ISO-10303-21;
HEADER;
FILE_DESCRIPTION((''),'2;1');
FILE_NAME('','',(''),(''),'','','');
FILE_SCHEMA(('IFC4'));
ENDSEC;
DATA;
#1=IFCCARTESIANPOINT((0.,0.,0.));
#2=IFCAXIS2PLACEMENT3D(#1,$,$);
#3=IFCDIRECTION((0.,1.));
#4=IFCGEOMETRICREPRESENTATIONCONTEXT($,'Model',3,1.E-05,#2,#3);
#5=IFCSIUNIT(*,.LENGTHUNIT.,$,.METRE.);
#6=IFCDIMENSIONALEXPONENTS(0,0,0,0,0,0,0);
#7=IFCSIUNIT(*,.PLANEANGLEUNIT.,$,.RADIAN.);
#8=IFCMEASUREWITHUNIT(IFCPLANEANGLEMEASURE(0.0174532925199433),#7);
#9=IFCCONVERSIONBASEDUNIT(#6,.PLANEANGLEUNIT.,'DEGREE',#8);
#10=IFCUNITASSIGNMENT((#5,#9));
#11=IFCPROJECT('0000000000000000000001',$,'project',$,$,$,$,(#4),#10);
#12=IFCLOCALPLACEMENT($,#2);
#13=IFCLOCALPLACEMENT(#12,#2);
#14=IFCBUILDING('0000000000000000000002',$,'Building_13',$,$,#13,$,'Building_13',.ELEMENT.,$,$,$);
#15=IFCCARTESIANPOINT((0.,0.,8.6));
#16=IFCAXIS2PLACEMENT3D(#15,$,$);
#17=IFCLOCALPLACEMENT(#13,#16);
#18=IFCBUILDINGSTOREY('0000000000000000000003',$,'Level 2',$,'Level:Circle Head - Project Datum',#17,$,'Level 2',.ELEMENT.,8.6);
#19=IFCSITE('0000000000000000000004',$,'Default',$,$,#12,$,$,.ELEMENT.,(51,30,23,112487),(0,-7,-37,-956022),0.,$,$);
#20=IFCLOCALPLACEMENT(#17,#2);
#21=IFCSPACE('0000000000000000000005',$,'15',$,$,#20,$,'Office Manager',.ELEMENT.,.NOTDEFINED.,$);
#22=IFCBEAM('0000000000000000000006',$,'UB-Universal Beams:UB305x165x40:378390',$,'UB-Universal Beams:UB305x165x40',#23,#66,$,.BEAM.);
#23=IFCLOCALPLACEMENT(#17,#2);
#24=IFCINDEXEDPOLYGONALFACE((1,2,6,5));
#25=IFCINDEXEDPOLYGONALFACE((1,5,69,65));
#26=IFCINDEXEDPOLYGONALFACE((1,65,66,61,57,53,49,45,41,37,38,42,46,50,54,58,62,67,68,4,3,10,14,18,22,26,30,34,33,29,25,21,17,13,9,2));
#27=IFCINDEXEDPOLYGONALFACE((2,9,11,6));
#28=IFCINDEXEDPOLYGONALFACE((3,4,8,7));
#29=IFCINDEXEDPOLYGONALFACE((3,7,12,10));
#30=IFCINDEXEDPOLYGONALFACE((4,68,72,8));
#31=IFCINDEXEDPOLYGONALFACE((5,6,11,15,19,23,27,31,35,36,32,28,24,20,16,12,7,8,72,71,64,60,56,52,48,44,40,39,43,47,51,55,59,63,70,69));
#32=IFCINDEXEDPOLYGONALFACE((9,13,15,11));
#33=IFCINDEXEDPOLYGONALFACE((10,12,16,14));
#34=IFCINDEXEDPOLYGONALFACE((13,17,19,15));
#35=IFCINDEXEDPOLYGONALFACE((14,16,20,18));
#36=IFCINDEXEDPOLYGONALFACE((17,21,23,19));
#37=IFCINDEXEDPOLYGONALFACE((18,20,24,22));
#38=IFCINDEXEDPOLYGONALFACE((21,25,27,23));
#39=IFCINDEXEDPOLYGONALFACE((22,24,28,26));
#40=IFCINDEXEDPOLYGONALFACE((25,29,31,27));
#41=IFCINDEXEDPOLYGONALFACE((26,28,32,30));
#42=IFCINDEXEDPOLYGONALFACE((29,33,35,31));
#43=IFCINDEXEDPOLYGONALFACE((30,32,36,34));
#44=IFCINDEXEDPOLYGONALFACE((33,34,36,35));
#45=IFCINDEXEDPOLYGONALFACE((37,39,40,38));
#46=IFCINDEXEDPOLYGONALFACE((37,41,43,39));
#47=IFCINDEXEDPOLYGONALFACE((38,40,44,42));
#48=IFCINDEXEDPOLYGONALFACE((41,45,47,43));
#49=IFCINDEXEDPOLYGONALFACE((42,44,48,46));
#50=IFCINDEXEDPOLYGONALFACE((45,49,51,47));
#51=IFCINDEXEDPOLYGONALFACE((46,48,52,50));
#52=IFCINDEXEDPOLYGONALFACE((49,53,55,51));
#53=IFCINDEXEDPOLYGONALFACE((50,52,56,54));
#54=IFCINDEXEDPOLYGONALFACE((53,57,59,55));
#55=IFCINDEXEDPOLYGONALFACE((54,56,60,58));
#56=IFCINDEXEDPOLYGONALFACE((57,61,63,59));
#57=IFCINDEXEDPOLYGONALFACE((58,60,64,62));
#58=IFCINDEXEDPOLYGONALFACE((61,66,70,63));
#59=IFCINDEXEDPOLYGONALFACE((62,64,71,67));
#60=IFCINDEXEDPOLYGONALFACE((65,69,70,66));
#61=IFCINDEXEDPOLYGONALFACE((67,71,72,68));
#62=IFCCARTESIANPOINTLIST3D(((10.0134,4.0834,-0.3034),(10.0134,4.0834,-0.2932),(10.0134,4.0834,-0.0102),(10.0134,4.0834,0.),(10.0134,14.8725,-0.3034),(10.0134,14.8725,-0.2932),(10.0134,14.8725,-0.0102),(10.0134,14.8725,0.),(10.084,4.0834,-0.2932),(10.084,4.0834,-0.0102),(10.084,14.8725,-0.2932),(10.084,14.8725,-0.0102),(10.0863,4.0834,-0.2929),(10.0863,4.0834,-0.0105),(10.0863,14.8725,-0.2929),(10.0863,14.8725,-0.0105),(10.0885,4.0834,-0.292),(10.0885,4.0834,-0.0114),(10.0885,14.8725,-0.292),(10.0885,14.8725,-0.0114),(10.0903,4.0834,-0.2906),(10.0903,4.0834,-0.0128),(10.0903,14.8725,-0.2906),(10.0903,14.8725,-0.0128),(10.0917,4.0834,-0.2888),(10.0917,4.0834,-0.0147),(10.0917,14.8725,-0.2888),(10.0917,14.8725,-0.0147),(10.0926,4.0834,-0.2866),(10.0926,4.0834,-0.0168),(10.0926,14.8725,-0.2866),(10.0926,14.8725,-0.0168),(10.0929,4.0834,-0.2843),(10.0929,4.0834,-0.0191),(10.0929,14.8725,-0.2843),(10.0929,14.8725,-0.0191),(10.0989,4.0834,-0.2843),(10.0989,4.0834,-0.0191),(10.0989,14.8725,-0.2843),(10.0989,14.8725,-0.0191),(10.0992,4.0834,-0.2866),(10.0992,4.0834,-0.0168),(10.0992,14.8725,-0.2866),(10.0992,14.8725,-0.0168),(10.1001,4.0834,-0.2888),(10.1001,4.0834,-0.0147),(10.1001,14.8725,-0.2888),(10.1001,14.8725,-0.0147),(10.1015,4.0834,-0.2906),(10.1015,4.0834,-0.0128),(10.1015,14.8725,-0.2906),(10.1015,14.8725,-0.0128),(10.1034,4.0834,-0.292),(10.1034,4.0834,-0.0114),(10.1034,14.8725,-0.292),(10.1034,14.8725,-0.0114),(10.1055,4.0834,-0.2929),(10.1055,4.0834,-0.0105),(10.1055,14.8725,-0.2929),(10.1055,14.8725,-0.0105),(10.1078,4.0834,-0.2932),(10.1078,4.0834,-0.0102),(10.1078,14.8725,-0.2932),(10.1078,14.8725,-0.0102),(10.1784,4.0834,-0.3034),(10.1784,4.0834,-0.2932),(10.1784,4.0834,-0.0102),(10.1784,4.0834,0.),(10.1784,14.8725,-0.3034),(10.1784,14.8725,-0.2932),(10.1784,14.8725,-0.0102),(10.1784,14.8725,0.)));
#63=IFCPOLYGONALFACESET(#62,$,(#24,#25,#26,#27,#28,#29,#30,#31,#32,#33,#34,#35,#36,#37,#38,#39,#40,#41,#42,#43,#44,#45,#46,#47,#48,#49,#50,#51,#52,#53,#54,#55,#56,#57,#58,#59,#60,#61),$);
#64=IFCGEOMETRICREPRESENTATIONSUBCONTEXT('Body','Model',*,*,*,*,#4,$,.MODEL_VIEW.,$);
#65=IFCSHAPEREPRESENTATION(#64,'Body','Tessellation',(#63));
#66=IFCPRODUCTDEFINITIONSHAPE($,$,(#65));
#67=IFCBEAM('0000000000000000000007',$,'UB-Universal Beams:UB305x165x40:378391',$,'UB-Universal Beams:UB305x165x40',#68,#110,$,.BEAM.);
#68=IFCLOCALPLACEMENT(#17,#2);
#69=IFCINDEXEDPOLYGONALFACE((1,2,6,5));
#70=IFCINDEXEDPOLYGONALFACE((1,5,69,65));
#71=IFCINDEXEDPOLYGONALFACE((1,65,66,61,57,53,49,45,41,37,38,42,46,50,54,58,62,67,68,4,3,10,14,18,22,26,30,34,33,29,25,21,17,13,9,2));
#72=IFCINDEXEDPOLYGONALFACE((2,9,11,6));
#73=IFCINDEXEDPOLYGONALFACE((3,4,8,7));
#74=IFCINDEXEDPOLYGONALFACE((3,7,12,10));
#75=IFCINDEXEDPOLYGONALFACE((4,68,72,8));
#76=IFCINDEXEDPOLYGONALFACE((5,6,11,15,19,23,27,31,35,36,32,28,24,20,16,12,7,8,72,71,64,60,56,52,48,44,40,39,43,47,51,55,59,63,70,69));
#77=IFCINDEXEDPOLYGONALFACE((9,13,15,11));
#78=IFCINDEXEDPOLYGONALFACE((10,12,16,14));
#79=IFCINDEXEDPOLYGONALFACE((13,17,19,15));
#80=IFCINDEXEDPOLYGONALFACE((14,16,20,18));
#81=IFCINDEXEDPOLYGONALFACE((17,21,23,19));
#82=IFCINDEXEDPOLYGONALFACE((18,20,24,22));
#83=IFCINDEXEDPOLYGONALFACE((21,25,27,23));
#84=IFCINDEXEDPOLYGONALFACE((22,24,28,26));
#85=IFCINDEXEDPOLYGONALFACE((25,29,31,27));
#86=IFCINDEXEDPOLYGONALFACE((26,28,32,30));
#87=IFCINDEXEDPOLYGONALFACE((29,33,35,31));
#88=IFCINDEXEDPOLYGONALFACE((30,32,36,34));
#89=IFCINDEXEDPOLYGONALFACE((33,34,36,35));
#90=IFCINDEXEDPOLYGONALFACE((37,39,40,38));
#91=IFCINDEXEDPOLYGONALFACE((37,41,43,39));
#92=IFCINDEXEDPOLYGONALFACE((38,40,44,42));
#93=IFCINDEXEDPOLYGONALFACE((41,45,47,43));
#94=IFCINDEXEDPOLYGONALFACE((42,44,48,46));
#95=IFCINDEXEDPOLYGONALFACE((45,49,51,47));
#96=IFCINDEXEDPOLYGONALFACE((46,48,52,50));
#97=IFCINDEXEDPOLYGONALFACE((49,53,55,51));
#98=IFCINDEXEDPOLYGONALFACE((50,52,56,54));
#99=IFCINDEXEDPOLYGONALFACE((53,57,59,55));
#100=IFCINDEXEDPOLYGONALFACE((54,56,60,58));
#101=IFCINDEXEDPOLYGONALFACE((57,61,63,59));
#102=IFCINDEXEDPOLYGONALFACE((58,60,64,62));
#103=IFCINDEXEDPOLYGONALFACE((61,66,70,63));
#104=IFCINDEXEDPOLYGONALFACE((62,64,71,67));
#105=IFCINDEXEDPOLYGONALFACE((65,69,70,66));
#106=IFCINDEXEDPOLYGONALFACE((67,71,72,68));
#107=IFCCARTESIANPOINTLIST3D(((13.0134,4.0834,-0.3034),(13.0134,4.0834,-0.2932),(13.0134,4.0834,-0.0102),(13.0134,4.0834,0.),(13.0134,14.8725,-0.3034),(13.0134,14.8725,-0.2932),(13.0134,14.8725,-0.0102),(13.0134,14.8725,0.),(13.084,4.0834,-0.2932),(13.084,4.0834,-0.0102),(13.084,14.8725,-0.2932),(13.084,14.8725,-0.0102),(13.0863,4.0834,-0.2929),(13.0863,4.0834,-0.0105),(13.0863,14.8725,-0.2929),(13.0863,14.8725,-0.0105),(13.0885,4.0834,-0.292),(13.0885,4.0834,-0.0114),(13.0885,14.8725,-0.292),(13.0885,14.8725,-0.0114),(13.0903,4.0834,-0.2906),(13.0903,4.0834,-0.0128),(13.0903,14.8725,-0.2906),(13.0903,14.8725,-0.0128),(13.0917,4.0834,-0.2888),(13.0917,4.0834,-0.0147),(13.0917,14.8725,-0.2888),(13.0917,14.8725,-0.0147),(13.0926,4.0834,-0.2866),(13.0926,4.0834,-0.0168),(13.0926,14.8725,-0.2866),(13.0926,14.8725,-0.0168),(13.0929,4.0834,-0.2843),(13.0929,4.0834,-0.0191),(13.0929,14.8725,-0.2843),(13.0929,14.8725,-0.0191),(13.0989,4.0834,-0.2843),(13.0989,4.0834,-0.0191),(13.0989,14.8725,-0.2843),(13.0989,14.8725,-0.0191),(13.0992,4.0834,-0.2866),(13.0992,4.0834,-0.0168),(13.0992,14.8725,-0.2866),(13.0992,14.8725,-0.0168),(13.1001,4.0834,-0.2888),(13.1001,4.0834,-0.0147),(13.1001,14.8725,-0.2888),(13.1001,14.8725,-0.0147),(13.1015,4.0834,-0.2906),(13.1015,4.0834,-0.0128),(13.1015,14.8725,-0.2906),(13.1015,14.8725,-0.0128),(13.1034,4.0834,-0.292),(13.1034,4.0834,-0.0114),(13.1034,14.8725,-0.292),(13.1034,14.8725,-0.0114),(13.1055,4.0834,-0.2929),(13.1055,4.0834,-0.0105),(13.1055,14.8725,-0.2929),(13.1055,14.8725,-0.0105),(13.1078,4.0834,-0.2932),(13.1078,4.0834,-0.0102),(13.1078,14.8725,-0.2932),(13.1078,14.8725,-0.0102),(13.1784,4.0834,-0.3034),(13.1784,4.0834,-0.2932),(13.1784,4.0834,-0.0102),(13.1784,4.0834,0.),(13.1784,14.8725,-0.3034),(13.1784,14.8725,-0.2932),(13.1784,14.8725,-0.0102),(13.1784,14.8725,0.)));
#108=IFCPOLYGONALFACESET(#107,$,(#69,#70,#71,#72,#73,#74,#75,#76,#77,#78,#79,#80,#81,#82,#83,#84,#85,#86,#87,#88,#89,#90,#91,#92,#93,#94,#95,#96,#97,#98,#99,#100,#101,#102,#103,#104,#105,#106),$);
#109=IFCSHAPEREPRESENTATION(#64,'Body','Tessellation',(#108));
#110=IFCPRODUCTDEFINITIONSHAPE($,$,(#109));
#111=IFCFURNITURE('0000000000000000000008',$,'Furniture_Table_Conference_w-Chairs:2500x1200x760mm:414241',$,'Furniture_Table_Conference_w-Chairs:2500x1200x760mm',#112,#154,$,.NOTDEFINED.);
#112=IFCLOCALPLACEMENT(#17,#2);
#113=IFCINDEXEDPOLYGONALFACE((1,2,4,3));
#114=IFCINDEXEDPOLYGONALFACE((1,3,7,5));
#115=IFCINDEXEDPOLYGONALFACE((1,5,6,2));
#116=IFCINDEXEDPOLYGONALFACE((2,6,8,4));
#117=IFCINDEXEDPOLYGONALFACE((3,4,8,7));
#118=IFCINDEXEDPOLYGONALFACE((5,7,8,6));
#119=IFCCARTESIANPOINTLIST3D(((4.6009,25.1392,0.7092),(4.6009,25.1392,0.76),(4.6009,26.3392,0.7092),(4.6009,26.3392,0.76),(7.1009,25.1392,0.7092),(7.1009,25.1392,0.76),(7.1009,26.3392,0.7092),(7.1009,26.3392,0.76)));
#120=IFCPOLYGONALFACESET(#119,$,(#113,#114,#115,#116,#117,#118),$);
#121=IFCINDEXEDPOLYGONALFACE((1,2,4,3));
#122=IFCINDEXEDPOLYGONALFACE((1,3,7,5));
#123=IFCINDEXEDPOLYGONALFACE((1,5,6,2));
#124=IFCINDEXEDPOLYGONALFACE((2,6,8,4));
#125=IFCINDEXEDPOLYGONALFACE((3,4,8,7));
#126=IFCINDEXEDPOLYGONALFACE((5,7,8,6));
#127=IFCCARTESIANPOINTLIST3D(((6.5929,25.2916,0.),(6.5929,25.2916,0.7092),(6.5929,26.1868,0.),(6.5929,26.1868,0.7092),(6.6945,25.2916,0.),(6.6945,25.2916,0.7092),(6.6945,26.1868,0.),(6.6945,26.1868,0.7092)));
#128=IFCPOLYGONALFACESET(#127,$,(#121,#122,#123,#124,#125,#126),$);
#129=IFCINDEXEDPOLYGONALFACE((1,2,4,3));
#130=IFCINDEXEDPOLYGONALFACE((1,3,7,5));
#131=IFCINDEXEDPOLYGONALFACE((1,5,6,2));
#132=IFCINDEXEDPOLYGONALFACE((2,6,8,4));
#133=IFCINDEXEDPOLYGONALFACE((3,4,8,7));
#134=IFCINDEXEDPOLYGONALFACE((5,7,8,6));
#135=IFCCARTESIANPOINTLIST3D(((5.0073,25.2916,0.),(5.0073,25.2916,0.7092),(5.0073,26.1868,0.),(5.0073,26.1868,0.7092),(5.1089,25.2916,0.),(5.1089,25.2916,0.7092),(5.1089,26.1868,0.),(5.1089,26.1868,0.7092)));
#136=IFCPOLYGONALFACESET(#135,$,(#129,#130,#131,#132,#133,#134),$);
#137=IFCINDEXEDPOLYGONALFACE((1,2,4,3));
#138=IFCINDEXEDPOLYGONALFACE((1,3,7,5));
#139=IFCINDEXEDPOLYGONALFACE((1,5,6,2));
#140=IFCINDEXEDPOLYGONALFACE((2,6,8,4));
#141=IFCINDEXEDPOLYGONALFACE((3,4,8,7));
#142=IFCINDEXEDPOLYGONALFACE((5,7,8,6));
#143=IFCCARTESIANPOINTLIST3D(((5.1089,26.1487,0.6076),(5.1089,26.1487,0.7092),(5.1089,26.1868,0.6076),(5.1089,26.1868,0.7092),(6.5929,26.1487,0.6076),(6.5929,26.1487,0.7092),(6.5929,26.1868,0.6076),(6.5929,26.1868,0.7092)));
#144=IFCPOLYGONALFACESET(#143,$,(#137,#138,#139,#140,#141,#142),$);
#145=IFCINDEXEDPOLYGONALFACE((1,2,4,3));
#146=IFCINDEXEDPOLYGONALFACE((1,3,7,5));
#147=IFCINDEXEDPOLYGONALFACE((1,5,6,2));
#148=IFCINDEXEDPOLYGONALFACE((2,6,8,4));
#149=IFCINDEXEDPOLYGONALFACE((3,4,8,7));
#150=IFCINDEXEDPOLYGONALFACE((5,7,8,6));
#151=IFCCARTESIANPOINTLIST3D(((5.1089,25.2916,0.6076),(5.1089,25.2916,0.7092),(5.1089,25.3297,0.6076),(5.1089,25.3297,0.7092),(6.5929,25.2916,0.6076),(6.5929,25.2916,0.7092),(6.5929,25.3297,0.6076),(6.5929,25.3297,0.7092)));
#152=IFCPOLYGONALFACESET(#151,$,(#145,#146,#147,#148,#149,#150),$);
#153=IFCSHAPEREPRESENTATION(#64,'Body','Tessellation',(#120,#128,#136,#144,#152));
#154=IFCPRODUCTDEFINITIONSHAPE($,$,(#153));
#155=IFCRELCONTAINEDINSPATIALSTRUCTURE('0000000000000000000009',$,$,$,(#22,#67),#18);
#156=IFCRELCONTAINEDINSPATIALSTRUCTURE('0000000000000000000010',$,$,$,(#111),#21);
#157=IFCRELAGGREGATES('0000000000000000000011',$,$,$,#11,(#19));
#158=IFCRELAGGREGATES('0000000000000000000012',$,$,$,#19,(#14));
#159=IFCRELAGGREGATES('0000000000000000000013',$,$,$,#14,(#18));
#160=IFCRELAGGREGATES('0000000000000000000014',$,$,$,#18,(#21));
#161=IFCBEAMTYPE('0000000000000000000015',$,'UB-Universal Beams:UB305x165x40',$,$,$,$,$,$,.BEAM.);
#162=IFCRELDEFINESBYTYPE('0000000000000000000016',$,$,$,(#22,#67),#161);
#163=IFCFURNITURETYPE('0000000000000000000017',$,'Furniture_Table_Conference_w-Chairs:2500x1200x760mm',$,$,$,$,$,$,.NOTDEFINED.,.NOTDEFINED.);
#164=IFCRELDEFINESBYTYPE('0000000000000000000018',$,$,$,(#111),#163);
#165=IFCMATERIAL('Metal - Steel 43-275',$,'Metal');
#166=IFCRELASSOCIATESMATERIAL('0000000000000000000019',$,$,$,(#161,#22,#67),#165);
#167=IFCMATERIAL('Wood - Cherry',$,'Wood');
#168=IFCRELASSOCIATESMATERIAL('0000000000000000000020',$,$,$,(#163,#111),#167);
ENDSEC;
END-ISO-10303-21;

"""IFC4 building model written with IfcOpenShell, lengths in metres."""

from ifc_helpers import new_model, entity, si_unit, converted_unit, direction, frame, origin, place, context, subcontext, project, spatial, line, arc, indexed_curve, outline, extrude, source, transform, mapped, material, type_object, type_shapes, element, save


model = new_model("IFC4")

# Units and contexts
model_context = context("Model", 3, precision=1e-05, world=origin(), true_north=direction((0.0, 1.0)))
body_context = subcontext(model_context, "Body", "Model", "MODEL_VIEW")
ifc_project = project(units=[si_unit("LENGTHUNIT", "METRE"), converted_unit("PLANEANGLEUNIT", "DEGREE", entity("IfcPlaneAngleMeasure", 0.0174532925199433), si_unit("PLANEANGLEUNIT", "RADIAN"), dimensions=[0, 0, 0, 0, 0, 0, 0])], contexts=[model_context])

# Site, building, storey
site_placement = place(None, origin())
site = spatial("IfcSite", under=ifc_project, at=site_placement, Name="Default", CompositionType="ELEMENT", RefLatitude=(51, 30, 23, 112487), RefLongitude=(0, -7, -37, -956022), RefElevation=0.0)
building_placement = place(site_placement, origin())
building = spatial("IfcBuilding", under=site, at=building_placement, Name="Building_13", LongName="Building_13", CompositionType="ELEMENT")
storey_placement = place(building_placement, frame((0.0, 0.0, 8.6)))
storey = spatial("IfcBuildingStorey", under=building, at=storey_placement, Name="Level 2", ObjectType="Level:Circle Head - Project Datum", LongName="Level 2", CompositionType="ELEMENT", Elevation=8.6)

# Beams
ifc_material_1 = material(Name="Metal - Steel 43-275", Category="Metal")
beam_type_1 = type_object("IfcBeamType", Name="UB-Universal Beams:UB305x165x40", PredefinedType="BEAM", material=ifc_material_1)
shared_shape_1 = source(origin(), body_context, "Body", "SweptSolid", [
    extrude(outline(indexed_curve([(-0.0825, -0.1415), (-0.0825, -0.1517), (0.0825, -0.1517), (0.0825, -0.1415), (0.0119, -0.1415), (0.0056, -0.1389), (0.003, -0.1326), (0.003, 0.1326), (0.0056, 0.1389), (0.0119, 0.1415), (0.0825, 0.1415), (0.0825, 0.1517), (-0.0825, 0.1517), (-0.0825, 0.1415), (-0.0119, 0.1415), (-0.0056, 0.1389), (-0.003, 0.1326), (-0.003, -0.1326), (-0.0056, -0.1389), (-0.0119, -0.1415)], segments=[line(1, 2, 3, 4, 5), arc(5, 6, 7), line(7, 8), arc(8, 9, 10), line(10, 11, 12, 13, 14, 15), arc(15, 16, 17), line(17, 18), arc(18, 19, 20), line(20, 1)], self_intersect=False)), frame((-5.3945, 0.0, 0.0), z_axis=(-1.0, 0.0, 0.0), x_axis=(0.0, -1.0, 0.0)), (0.0, 0.0, -1.0), 10.7891),
])
type_shapes(beam_type_1, [shared_shape_1])
for number, where, z_axis, x_axis, name in (
    (1, (10.0959, 9.4779, -0.1517), (0.0, 0.0, 1.0), (0.0, 1.0, 0.0), "UB-Universal Beams:UB305x165x40:378390"),
    (2, (13.0959, 9.4779, -0.1517), (0.0, 0.0, 1.0), (0.0, -1.0, 0.0), "UB-Universal Beams:UB305x165x40:378391"),
):
    element("IfcBeam", number, at=place(storey_placement, frame(where, z_axis=z_axis, x_axis=x_axis)), inside=storey, type_object=beam_type_1, material=ifc_material_1, Name=name, ObjectType="UB-Universal Beams:UB305x165x40", PredefinedType="BEAM", context=body_context, shape_type="MappedRepresentation", body=[
        mapped(shared_shape_1, transform((0.0, 0.0, 0.0), scale=1.0)),
    ])

# Shared definitions
space_placement = place(storey_placement, origin())
space = spatial("IfcSpace", under=storey, at=space_placement, Name="15", LongName="Office Manager", CompositionType="ELEMENT", PredefinedType="NOTDEFINED")

# Furniture
ifc_material_2 = material(Name="Wood - Cherry", Category="Wood")
furniture_type_1 = type_object("IfcFurnitureType", Name="Furniture_Table_Conference_w-Chairs:2500x1200x760mm", AssemblyPlace="NOTDEFINED", PredefinedType="NOTDEFINED", material=ifc_material_2)
shared_shape_2 = source(origin(), body_context, "Body", "SweptSolid", [
    extrude(outline(indexed_curve([(-0.6, -1.25), (0.6, -1.25), (0.6, 1.25), (-0.6, 1.25), (-0.6, -1.25)], self_intersect=False)), frame((0.0, 0.0, 0.7092), z_axis=(0.0, 0.0, 1.0), x_axis=(0.0, 1.0, 0.0)), (0.0, 0.0, 1.0), 0.0508),
    extrude(outline(indexed_curve([(-0.4476, -0.0508), (0.4476, -0.0508), (0.4476, 0.0508), (-0.4476, 0.0508), (-0.4476, -0.0508)], self_intersect=False)), frame((0.7928, 0.0, 0.0), z_axis=(0.0, 0.0, 1.0), x_axis=(0.0, 1.0, 0.0)), (0.0, 0.0, 1.0), 0.7092),
    extrude(outline(indexed_curve([(-0.4476, -0.0508), (0.4476, -0.0508), (0.4476, 0.0508), (-0.4476, 0.0508), (-0.4476, -0.0508)], self_intersect=False)), frame((-0.7928, 0.0, 0.0), z_axis=(0.0, 0.0, 1.0), x_axis=(0.0, 1.0, 0.0)), (0.0, 0.0, 1.0), 0.7092),
    extrude(outline(indexed_curve([(-0.742, -0.0191), (0.742, -0.0191), (0.742, 0.0191), (-0.742, 0.0191), (-0.742, -0.0191)], self_intersect=False)), frame((0.0, 0.4286, 0.6076), z_axis=(0.0, 0.0, 1.0), x_axis=(-1.0, 0.0, 0.0)), (0.0, 0.0, 1.0), 0.1016),
    extrude(outline(indexed_curve([(-0.019, -0.742), (0.019, -0.742), (0.019, 0.742), (-0.019, 0.742), (-0.019, -0.742)], self_intersect=False)), frame((0.0, -0.4286, 0.6076), z_axis=(0.0, 0.0, 1.0), x_axis=(0.0, 1.0, 0.0)), (0.0, 0.0, 1.0), 0.1016),
])
type_shapes(furniture_type_1, [shared_shape_2])
furniture_1_placement = place(space_placement, frame((5.8509, 25.7392, 0.0)))
element("IfcFurniture", 3, at=furniture_1_placement, inside=space, type_object=furniture_type_1, material=ifc_material_2, Name="Furniture_Table_Conference_w-Chairs:2500x1200x760mm:414241", ObjectType="Furniture_Table_Conference_w-Chairs:2500x1200x760mm", PredefinedType="NOTDEFINED", context=body_context, shape_type="MappedRepresentation", body=[
    mapped(shared_shape_2, transform((0.0, 0.0, 0.0), scale=1.0)),
])

save(model, "model.ifc")
